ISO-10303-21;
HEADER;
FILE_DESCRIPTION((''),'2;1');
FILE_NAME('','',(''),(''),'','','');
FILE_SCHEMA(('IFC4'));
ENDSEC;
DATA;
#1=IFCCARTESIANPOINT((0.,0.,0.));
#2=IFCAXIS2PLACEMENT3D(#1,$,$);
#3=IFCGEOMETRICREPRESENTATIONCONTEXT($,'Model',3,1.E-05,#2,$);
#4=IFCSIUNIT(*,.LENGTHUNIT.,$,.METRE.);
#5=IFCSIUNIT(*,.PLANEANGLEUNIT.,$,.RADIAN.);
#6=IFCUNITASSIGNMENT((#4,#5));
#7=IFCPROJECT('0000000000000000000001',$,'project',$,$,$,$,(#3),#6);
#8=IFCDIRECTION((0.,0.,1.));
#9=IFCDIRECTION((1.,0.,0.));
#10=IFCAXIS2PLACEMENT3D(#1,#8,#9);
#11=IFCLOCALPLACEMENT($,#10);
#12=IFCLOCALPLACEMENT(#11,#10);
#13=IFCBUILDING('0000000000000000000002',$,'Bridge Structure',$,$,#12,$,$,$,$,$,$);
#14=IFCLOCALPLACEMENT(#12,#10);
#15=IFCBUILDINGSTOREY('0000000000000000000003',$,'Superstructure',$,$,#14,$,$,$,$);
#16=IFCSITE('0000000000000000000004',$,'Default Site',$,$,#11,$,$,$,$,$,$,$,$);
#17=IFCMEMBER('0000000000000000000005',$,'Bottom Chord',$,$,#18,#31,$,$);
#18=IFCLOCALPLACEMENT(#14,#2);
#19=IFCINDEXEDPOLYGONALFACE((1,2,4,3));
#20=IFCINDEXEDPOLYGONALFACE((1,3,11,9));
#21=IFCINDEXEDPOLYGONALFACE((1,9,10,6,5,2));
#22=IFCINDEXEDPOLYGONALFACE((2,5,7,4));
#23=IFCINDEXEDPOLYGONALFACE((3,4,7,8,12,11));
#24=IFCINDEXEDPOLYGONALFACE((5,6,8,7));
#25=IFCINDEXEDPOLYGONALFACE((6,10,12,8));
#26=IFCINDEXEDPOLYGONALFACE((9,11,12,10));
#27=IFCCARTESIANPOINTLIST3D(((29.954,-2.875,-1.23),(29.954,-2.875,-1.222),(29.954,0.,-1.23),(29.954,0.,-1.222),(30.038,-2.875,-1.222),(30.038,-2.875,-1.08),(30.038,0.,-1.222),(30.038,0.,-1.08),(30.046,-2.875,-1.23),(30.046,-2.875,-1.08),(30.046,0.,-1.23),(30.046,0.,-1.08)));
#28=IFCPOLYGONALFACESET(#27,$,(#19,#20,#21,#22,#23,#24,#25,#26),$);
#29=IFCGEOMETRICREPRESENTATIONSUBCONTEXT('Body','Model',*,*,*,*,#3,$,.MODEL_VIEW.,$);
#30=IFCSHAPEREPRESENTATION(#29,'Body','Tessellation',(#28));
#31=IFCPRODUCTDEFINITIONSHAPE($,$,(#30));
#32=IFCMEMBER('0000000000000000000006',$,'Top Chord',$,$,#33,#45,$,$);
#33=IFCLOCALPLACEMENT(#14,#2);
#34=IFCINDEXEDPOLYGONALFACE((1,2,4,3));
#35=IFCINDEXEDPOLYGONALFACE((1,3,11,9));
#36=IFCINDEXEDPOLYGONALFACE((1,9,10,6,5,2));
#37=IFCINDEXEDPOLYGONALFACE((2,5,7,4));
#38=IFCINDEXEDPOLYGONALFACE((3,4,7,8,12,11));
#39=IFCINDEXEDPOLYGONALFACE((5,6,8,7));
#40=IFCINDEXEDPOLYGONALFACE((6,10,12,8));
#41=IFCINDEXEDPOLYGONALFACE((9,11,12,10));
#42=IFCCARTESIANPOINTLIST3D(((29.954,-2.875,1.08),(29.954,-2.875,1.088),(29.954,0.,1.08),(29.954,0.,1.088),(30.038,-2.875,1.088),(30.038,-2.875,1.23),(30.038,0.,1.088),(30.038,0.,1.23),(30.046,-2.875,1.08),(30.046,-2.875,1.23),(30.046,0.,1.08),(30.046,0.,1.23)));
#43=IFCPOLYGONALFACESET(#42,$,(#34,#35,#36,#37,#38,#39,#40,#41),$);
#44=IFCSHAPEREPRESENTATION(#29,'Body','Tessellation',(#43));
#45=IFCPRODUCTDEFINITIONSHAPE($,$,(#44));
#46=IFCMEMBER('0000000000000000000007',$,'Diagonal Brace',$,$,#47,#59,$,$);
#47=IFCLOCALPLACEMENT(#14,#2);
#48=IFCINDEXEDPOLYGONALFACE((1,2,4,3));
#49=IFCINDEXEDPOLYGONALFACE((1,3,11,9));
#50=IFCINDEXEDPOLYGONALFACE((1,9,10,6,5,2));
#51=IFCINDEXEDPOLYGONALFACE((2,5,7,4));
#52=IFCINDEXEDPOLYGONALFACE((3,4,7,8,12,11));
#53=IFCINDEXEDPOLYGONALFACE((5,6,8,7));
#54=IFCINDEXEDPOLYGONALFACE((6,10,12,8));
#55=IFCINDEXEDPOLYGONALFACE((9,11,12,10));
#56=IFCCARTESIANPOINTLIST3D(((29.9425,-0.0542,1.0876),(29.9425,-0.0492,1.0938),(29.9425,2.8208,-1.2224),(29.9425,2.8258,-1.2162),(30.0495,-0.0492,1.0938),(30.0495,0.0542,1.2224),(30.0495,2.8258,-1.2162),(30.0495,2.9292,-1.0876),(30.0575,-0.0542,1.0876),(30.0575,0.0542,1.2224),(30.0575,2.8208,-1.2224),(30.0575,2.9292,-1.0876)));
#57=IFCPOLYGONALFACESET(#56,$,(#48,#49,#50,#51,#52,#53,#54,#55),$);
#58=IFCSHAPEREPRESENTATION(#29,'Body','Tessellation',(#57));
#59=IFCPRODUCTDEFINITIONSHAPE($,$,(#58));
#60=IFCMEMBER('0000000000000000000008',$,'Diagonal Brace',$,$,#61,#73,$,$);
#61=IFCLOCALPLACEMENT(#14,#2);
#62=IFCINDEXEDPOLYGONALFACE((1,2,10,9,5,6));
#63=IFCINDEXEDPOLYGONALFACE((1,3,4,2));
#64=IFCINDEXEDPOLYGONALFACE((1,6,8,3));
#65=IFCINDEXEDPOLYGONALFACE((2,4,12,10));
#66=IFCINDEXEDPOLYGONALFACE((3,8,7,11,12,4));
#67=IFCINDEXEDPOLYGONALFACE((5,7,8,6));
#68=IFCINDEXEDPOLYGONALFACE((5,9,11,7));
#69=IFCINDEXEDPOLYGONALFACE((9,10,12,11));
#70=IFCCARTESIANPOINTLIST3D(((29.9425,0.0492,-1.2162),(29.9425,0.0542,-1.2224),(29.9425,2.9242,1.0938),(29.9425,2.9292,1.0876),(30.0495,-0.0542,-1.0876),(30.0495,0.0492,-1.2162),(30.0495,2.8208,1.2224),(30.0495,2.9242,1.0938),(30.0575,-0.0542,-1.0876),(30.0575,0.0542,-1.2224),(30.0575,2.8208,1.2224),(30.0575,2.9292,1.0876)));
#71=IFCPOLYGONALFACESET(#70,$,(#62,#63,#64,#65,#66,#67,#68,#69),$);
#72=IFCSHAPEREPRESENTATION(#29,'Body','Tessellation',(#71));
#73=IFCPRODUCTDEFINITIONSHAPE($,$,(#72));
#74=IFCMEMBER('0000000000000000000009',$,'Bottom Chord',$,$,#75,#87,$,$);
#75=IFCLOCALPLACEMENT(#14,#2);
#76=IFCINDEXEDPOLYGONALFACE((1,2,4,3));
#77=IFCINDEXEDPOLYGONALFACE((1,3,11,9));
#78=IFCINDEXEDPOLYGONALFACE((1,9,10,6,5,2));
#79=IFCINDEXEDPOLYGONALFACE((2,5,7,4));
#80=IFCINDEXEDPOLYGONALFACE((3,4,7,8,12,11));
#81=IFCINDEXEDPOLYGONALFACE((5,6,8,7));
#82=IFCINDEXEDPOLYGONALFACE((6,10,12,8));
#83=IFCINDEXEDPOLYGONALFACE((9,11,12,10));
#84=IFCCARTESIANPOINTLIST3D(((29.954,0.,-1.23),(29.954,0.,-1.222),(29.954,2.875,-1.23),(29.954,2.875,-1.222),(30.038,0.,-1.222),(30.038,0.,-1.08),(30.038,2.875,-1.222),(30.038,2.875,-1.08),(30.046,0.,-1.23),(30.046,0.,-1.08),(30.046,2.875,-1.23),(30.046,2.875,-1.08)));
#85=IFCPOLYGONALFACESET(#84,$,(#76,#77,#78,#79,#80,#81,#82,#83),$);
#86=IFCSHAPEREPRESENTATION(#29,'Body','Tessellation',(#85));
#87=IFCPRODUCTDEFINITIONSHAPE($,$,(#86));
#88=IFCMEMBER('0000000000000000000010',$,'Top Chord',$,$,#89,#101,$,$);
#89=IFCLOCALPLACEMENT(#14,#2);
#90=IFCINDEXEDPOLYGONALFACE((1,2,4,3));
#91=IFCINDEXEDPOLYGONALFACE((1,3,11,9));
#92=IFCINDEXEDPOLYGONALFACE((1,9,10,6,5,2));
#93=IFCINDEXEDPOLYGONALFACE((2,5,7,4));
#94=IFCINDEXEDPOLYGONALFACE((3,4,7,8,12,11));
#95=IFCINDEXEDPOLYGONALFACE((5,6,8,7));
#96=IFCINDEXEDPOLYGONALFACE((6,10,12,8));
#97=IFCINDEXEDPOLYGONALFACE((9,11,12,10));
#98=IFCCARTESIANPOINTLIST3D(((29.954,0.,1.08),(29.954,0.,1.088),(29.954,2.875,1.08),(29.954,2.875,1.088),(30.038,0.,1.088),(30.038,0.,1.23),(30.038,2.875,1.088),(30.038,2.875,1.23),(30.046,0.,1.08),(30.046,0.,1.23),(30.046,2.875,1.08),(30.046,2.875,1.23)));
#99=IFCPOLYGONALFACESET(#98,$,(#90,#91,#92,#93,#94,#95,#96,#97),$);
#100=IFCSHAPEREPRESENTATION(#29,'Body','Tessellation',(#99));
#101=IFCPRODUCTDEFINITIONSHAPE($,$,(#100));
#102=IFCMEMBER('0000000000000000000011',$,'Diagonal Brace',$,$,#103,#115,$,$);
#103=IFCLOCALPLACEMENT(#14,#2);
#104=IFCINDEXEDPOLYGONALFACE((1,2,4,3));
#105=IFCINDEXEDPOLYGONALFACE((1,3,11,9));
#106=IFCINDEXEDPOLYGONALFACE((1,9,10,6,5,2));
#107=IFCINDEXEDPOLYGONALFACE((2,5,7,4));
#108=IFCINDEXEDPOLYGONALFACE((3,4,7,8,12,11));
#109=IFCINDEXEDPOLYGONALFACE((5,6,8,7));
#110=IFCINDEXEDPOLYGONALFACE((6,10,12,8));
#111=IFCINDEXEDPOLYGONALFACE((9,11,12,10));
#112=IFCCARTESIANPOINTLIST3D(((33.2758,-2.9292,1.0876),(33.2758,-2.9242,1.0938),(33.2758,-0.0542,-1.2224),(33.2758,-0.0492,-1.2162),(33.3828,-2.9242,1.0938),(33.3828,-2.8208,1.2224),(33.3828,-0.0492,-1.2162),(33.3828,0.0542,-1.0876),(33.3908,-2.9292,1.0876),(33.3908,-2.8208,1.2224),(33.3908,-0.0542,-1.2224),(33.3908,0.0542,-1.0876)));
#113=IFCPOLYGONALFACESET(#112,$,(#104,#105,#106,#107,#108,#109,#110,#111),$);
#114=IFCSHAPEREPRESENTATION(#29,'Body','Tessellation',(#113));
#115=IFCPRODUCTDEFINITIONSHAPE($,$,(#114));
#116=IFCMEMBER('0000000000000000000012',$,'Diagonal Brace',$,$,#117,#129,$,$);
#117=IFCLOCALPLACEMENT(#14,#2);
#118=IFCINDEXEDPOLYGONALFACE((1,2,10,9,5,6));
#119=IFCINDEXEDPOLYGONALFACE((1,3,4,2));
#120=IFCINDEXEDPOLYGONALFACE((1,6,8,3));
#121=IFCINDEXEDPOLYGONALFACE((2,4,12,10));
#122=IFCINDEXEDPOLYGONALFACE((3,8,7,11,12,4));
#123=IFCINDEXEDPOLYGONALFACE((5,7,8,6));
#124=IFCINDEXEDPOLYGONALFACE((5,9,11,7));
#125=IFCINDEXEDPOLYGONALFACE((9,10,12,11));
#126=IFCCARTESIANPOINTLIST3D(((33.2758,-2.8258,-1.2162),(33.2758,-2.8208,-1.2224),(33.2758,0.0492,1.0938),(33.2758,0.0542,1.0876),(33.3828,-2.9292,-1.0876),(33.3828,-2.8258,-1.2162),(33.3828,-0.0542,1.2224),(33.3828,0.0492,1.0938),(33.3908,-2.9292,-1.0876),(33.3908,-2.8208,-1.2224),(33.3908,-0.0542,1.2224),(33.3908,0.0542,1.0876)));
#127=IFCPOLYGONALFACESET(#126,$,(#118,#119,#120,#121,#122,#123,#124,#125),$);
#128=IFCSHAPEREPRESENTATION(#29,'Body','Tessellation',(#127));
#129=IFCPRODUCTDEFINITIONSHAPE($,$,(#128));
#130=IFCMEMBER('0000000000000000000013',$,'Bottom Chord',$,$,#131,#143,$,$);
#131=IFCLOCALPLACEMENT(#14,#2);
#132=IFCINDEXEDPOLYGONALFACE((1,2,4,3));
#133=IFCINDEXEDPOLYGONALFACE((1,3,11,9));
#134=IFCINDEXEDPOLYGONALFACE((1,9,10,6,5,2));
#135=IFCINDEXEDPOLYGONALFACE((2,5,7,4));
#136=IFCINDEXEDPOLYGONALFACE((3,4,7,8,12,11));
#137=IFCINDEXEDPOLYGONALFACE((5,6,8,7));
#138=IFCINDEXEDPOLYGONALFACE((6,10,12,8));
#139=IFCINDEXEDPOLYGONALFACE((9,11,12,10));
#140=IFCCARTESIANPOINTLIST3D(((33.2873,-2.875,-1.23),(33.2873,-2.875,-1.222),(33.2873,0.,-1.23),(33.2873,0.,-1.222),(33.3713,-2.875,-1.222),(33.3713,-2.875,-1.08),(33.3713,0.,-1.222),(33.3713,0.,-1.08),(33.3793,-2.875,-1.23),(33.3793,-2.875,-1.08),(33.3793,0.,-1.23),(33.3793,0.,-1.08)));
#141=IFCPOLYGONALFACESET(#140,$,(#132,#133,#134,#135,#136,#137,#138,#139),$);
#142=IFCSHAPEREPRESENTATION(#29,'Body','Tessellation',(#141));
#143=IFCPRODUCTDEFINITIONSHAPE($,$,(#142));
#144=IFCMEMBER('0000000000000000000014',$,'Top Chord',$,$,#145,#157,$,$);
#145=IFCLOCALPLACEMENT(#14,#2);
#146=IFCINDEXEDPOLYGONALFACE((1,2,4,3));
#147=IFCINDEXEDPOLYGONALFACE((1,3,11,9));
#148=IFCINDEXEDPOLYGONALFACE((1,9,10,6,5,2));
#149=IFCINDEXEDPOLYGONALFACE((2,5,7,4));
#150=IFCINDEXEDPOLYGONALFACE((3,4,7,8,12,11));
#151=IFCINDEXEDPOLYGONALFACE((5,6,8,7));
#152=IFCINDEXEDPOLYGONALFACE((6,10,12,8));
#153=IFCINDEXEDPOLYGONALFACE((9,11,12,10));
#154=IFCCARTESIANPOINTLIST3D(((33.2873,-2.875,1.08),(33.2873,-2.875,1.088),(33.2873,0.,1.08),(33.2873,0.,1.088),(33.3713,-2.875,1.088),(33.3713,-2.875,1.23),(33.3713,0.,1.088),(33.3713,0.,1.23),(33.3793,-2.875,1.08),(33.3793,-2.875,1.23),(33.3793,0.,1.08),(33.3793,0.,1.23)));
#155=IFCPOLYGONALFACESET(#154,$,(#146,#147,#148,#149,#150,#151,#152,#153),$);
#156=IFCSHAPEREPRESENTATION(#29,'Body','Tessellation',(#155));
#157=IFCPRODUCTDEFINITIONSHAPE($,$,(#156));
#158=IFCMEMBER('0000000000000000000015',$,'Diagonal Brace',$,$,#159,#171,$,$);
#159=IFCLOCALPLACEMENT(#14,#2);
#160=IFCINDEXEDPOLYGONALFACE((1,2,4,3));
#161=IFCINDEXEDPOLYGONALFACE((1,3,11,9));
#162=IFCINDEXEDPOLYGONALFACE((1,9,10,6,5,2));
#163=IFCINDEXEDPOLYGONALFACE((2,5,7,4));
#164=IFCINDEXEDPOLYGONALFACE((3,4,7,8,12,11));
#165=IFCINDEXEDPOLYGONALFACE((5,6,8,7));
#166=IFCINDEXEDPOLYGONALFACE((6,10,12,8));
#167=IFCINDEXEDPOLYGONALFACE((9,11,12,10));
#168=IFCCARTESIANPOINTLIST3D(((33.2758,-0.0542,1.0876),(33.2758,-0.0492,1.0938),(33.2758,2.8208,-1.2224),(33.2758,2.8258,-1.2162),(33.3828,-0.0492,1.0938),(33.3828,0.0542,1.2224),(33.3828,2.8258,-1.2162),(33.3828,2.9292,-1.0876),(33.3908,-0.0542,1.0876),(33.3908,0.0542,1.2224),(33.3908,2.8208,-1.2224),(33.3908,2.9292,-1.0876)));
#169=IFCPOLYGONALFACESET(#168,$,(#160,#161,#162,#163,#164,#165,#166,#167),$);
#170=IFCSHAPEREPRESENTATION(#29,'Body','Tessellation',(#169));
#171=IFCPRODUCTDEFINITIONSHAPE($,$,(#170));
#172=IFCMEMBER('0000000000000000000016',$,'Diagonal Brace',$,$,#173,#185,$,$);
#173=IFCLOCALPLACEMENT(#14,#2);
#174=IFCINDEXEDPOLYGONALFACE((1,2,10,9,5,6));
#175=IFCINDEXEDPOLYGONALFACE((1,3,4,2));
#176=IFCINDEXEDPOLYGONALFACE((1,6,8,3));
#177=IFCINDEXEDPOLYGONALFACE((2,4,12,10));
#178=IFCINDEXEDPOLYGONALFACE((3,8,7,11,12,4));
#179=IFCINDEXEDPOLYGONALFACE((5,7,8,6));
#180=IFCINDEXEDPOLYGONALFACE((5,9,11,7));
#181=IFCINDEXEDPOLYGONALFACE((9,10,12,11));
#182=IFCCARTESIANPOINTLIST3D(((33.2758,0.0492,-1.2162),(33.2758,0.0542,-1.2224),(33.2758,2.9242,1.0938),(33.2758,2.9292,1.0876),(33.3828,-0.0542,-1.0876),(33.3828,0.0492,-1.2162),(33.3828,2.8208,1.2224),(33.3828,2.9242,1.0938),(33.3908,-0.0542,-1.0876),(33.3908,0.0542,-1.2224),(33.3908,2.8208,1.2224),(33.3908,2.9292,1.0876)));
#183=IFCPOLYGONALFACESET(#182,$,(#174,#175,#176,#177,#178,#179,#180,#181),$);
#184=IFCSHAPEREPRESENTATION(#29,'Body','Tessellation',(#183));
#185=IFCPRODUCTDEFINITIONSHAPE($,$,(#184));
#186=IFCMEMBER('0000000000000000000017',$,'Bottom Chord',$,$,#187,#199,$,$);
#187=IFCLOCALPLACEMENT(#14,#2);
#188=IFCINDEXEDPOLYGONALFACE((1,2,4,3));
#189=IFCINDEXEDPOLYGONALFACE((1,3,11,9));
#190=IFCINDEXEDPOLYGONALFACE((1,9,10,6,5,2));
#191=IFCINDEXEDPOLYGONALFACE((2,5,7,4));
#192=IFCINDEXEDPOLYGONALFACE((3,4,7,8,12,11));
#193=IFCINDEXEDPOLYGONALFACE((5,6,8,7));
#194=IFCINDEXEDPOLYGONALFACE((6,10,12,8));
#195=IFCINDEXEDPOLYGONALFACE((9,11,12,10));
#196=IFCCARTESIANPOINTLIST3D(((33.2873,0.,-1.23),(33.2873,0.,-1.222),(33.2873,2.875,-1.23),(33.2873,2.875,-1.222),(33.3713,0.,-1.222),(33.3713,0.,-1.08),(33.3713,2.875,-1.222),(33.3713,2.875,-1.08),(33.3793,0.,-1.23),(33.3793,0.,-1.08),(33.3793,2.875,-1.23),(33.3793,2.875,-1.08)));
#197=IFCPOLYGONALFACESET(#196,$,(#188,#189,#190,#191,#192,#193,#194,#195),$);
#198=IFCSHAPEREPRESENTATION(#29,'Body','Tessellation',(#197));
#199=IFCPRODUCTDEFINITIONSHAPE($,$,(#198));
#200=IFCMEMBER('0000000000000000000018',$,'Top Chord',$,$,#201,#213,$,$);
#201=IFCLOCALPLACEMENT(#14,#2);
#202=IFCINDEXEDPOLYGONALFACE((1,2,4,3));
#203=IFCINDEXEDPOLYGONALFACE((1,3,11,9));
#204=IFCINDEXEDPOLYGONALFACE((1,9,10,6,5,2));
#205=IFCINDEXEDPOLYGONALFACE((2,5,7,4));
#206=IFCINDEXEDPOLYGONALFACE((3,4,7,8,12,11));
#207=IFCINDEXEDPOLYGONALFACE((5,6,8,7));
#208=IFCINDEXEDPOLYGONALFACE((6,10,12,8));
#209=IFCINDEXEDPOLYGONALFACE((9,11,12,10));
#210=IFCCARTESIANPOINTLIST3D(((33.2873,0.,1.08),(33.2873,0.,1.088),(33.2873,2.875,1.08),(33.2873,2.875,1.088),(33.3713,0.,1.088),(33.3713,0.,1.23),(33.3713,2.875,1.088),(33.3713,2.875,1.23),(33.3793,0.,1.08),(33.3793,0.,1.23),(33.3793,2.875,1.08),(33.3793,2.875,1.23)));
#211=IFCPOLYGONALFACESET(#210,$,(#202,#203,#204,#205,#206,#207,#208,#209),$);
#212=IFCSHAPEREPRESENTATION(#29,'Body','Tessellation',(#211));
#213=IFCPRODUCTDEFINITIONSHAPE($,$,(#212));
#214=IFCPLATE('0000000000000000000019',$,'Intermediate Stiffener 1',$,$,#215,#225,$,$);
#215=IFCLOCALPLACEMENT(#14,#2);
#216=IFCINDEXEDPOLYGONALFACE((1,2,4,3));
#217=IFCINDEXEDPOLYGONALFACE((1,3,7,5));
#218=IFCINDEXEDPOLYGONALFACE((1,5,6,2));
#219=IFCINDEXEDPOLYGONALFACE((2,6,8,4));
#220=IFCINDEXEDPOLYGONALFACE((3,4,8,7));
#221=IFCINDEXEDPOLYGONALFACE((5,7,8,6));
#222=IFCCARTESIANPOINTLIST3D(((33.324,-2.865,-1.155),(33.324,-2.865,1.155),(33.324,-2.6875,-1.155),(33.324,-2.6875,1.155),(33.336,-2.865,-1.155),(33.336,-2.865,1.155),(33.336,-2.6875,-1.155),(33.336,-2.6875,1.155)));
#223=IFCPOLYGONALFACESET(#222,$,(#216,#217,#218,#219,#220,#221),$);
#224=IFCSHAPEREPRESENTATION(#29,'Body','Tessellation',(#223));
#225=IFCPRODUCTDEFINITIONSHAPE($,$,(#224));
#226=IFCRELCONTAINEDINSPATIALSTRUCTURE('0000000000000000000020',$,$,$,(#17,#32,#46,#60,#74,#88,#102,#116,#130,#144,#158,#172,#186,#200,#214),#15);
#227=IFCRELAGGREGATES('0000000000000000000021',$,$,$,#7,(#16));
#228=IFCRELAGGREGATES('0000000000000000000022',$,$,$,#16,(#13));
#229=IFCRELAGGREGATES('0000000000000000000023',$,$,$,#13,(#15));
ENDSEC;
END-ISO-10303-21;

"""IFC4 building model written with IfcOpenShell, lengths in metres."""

from ifc_helpers import new_model, si_unit, frame, origin, origin_with_axes, origin_2d_with_axis, place, context, subcontext, project, spatial, rectangle, l_section, extrude, element, save


model = new_model("IFC4")

# Units and contexts
model_context = context("Model", 3, precision=1e-05, world=origin())
body_context = subcontext(model_context, "Body", "Model", "MODEL_VIEW")
ifc_project = project(units=[si_unit("LENGTHUNIT", "METRE"), si_unit("PLANEANGLEUNIT", "RADIAN")], contexts=[model_context])

# Site, building, storey
site_placement = place(None, origin_with_axes())
site = spatial("IfcSite", under=ifc_project, at=site_placement, Name="Default Site")
building_placement = place(site_placement, origin_with_axes())
building = spatial("IfcBuilding", under=site, at=building_placement, Name="Bridge Structure")
storey_placement = place(building_placement, origin_with_axes())
storey = spatial("IfcBuildingStorey", under=building, at=storey_placement, Name="Superstructure")

# Members
for number, where, z_axis, x_axis, name in (
    (1, (30.0, -2.875, -1.155), (0.0, 1.0, 0.0), (-1.0, 0.0, 0.0), "Bottom Chord"),
    (2, (30.0, -2.875, 1.155), (0.0, 1.0, 0.0), (-1.0, 0.0, 0.0), "Top Chord"),
):
    element("IfcMember", number, at=place(storey_placement, frame(where, z_axis=z_axis, x_axis=x_axis)), inside=storey, Name=name, context=body_context, shape_type="SweptSolid", body=[
        extrude(l_section(Depth=0.15, Width=0.092, Thickness=0.008, at=origin_2d_with_axis()), origin_with_axes(), (0.0, 0.0, 1.0), 2.875),
    ])
for number, where, z_axis, x_axis, name in (
    (3, (30.0, 0.0, 1.155), (0.0, 0.779544, -0.626347), (-1.0, 0.0, 0.0), "Diagonal Brace"),
    (4, (30.0, 0.0, -1.155), (0.0, 0.779544, 0.626347), (-1.0, 0.0, 0.0), "Diagonal Brace"),
):
    element("IfcMember", number, at=place(storey_placement, frame(where, z_axis=z_axis, x_axis=x_axis)), inside=storey, Name=name, context=body_context, shape_type="SweptSolid", body=[
        extrude(l_section(Depth=0.173, Width=0.115, Thickness=0.008, at=origin_2d_with_axis()), origin_with_axes(), (0.0, 0.0, 1.0), 3.6881),
    ])
for number, where, z_axis, x_axis, name in (
    (5, (30.0, 0.0, -1.155), (0.0, 1.0, 0.0), (-1.0, 0.0, 0.0), "Bottom Chord"),
    (6, (30.0, 0.0, 1.155), (0.0, 1.0, 0.0), (-1.0, 0.0, 0.0), "Top Chord"),
):
    element("IfcMember", number, at=place(storey_placement, frame(where, z_axis=z_axis, x_axis=x_axis)), inside=storey, Name=name, context=body_context, shape_type="SweptSolid", body=[
        extrude(l_section(Depth=0.15, Width=0.092, Thickness=0.008, at=origin_2d_with_axis()), origin_with_axes(), (0.0, 0.0, 1.0), 2.875),
    ])
for number, where, z_axis, x_axis, name in (
    (7, (33.3333, -2.875, 1.155), (0.0, 0.779544, -0.626347), (-1.0, 0.0, 0.0), "Diagonal Brace"),
    (8, (33.3333, -2.875, -1.155), (0.0, 0.779544, 0.626347), (-1.0, 0.0, 0.0), "Diagonal Brace"),
):
    element("IfcMember", number, at=place(storey_placement, frame(where, z_axis=z_axis, x_axis=x_axis)), inside=storey, Name=name, context=body_context, shape_type="SweptSolid", body=[
        extrude(l_section(Depth=0.173, Width=0.115, Thickness=0.008, at=origin_2d_with_axis()), origin_with_axes(), (0.0, 0.0, 1.0), 3.6881),
    ])
for number, where, z_axis, x_axis, name in (
    (9, (33.3333, -2.875, -1.155), (0.0, 1.0, 0.0), (-1.0, 0.0, 0.0), "Bottom Chord"),
    (10, (33.3333, -2.875, 1.155), (0.0, 1.0, 0.0), (-1.0, 0.0, 0.0), "Top Chord"),
):
    element("IfcMember", number, at=place(storey_placement, frame(where, z_axis=z_axis, x_axis=x_axis)), inside=storey, Name=name, context=body_context, shape_type="SweptSolid", body=[
        extrude(l_section(Depth=0.15, Width=0.092, Thickness=0.008, at=origin_2d_with_axis()), origin_with_axes(), (0.0, 0.0, 1.0), 2.875),
    ])
for number, where, z_axis, x_axis, name in (
    (11, (33.3333, 0.0, 1.155), (0.0, 0.779544, -0.626347), (-1.0, 0.0, 0.0), "Diagonal Brace"),
    (12, (33.3333, 0.0, -1.155), (0.0, 0.779544, 0.626347), (-1.0, 0.0, 0.0), "Diagonal Brace"),
):
    element("IfcMember", number, at=place(storey_placement, frame(where, z_axis=z_axis, x_axis=x_axis)), inside=storey, Name=name, context=body_context, shape_type="SweptSolid", body=[
        extrude(l_section(Depth=0.173, Width=0.115, Thickness=0.008, at=origin_2d_with_axis()), origin_with_axes(), (0.0, 0.0, 1.0), 3.6881),
    ])
for number, where, z_axis, x_axis, name in (
    (13, (33.3333, 0.0, -1.155), (0.0, 1.0, 0.0), (-1.0, 0.0, 0.0), "Bottom Chord"),
    (14, (33.3333, 0.0, 1.155), (0.0, 1.0, 0.0), (-1.0, 0.0, 0.0), "Top Chord"),
):
    element("IfcMember", number, at=place(storey_placement, frame(where, z_axis=z_axis, x_axis=x_axis)), inside=storey, Name=name, context=body_context, shape_type="SweptSolid", body=[
        extrude(l_section(Depth=0.15, Width=0.092, Thickness=0.008, at=origin_2d_with_axis()), origin_with_axes(), (0.0, 0.0, 1.0), 2.875),
    ])

# Plate
for number, where, z_axis, x_axis, name in (
    (15, (33.33, -2.7763, -1.155), (0.0, 0.0, 1.0), (1.0, 0.0, 0.0), "Intermediate Stiffener 1"),
):
    element("IfcPlate", number, at=place(storey_placement, frame(where, z_axis=z_axis, x_axis=x_axis)), inside=storey, Name=name, context=body_context, shape_type="SweptSolid", body=[
        extrude(rectangle(XDim=0.012, YDim=0.1775, at=origin_2d_with_axis()), origin_with_axes(), (0.0, 0.0, 1.0), 2.31),
    ])

save(model, "model.ifc")
